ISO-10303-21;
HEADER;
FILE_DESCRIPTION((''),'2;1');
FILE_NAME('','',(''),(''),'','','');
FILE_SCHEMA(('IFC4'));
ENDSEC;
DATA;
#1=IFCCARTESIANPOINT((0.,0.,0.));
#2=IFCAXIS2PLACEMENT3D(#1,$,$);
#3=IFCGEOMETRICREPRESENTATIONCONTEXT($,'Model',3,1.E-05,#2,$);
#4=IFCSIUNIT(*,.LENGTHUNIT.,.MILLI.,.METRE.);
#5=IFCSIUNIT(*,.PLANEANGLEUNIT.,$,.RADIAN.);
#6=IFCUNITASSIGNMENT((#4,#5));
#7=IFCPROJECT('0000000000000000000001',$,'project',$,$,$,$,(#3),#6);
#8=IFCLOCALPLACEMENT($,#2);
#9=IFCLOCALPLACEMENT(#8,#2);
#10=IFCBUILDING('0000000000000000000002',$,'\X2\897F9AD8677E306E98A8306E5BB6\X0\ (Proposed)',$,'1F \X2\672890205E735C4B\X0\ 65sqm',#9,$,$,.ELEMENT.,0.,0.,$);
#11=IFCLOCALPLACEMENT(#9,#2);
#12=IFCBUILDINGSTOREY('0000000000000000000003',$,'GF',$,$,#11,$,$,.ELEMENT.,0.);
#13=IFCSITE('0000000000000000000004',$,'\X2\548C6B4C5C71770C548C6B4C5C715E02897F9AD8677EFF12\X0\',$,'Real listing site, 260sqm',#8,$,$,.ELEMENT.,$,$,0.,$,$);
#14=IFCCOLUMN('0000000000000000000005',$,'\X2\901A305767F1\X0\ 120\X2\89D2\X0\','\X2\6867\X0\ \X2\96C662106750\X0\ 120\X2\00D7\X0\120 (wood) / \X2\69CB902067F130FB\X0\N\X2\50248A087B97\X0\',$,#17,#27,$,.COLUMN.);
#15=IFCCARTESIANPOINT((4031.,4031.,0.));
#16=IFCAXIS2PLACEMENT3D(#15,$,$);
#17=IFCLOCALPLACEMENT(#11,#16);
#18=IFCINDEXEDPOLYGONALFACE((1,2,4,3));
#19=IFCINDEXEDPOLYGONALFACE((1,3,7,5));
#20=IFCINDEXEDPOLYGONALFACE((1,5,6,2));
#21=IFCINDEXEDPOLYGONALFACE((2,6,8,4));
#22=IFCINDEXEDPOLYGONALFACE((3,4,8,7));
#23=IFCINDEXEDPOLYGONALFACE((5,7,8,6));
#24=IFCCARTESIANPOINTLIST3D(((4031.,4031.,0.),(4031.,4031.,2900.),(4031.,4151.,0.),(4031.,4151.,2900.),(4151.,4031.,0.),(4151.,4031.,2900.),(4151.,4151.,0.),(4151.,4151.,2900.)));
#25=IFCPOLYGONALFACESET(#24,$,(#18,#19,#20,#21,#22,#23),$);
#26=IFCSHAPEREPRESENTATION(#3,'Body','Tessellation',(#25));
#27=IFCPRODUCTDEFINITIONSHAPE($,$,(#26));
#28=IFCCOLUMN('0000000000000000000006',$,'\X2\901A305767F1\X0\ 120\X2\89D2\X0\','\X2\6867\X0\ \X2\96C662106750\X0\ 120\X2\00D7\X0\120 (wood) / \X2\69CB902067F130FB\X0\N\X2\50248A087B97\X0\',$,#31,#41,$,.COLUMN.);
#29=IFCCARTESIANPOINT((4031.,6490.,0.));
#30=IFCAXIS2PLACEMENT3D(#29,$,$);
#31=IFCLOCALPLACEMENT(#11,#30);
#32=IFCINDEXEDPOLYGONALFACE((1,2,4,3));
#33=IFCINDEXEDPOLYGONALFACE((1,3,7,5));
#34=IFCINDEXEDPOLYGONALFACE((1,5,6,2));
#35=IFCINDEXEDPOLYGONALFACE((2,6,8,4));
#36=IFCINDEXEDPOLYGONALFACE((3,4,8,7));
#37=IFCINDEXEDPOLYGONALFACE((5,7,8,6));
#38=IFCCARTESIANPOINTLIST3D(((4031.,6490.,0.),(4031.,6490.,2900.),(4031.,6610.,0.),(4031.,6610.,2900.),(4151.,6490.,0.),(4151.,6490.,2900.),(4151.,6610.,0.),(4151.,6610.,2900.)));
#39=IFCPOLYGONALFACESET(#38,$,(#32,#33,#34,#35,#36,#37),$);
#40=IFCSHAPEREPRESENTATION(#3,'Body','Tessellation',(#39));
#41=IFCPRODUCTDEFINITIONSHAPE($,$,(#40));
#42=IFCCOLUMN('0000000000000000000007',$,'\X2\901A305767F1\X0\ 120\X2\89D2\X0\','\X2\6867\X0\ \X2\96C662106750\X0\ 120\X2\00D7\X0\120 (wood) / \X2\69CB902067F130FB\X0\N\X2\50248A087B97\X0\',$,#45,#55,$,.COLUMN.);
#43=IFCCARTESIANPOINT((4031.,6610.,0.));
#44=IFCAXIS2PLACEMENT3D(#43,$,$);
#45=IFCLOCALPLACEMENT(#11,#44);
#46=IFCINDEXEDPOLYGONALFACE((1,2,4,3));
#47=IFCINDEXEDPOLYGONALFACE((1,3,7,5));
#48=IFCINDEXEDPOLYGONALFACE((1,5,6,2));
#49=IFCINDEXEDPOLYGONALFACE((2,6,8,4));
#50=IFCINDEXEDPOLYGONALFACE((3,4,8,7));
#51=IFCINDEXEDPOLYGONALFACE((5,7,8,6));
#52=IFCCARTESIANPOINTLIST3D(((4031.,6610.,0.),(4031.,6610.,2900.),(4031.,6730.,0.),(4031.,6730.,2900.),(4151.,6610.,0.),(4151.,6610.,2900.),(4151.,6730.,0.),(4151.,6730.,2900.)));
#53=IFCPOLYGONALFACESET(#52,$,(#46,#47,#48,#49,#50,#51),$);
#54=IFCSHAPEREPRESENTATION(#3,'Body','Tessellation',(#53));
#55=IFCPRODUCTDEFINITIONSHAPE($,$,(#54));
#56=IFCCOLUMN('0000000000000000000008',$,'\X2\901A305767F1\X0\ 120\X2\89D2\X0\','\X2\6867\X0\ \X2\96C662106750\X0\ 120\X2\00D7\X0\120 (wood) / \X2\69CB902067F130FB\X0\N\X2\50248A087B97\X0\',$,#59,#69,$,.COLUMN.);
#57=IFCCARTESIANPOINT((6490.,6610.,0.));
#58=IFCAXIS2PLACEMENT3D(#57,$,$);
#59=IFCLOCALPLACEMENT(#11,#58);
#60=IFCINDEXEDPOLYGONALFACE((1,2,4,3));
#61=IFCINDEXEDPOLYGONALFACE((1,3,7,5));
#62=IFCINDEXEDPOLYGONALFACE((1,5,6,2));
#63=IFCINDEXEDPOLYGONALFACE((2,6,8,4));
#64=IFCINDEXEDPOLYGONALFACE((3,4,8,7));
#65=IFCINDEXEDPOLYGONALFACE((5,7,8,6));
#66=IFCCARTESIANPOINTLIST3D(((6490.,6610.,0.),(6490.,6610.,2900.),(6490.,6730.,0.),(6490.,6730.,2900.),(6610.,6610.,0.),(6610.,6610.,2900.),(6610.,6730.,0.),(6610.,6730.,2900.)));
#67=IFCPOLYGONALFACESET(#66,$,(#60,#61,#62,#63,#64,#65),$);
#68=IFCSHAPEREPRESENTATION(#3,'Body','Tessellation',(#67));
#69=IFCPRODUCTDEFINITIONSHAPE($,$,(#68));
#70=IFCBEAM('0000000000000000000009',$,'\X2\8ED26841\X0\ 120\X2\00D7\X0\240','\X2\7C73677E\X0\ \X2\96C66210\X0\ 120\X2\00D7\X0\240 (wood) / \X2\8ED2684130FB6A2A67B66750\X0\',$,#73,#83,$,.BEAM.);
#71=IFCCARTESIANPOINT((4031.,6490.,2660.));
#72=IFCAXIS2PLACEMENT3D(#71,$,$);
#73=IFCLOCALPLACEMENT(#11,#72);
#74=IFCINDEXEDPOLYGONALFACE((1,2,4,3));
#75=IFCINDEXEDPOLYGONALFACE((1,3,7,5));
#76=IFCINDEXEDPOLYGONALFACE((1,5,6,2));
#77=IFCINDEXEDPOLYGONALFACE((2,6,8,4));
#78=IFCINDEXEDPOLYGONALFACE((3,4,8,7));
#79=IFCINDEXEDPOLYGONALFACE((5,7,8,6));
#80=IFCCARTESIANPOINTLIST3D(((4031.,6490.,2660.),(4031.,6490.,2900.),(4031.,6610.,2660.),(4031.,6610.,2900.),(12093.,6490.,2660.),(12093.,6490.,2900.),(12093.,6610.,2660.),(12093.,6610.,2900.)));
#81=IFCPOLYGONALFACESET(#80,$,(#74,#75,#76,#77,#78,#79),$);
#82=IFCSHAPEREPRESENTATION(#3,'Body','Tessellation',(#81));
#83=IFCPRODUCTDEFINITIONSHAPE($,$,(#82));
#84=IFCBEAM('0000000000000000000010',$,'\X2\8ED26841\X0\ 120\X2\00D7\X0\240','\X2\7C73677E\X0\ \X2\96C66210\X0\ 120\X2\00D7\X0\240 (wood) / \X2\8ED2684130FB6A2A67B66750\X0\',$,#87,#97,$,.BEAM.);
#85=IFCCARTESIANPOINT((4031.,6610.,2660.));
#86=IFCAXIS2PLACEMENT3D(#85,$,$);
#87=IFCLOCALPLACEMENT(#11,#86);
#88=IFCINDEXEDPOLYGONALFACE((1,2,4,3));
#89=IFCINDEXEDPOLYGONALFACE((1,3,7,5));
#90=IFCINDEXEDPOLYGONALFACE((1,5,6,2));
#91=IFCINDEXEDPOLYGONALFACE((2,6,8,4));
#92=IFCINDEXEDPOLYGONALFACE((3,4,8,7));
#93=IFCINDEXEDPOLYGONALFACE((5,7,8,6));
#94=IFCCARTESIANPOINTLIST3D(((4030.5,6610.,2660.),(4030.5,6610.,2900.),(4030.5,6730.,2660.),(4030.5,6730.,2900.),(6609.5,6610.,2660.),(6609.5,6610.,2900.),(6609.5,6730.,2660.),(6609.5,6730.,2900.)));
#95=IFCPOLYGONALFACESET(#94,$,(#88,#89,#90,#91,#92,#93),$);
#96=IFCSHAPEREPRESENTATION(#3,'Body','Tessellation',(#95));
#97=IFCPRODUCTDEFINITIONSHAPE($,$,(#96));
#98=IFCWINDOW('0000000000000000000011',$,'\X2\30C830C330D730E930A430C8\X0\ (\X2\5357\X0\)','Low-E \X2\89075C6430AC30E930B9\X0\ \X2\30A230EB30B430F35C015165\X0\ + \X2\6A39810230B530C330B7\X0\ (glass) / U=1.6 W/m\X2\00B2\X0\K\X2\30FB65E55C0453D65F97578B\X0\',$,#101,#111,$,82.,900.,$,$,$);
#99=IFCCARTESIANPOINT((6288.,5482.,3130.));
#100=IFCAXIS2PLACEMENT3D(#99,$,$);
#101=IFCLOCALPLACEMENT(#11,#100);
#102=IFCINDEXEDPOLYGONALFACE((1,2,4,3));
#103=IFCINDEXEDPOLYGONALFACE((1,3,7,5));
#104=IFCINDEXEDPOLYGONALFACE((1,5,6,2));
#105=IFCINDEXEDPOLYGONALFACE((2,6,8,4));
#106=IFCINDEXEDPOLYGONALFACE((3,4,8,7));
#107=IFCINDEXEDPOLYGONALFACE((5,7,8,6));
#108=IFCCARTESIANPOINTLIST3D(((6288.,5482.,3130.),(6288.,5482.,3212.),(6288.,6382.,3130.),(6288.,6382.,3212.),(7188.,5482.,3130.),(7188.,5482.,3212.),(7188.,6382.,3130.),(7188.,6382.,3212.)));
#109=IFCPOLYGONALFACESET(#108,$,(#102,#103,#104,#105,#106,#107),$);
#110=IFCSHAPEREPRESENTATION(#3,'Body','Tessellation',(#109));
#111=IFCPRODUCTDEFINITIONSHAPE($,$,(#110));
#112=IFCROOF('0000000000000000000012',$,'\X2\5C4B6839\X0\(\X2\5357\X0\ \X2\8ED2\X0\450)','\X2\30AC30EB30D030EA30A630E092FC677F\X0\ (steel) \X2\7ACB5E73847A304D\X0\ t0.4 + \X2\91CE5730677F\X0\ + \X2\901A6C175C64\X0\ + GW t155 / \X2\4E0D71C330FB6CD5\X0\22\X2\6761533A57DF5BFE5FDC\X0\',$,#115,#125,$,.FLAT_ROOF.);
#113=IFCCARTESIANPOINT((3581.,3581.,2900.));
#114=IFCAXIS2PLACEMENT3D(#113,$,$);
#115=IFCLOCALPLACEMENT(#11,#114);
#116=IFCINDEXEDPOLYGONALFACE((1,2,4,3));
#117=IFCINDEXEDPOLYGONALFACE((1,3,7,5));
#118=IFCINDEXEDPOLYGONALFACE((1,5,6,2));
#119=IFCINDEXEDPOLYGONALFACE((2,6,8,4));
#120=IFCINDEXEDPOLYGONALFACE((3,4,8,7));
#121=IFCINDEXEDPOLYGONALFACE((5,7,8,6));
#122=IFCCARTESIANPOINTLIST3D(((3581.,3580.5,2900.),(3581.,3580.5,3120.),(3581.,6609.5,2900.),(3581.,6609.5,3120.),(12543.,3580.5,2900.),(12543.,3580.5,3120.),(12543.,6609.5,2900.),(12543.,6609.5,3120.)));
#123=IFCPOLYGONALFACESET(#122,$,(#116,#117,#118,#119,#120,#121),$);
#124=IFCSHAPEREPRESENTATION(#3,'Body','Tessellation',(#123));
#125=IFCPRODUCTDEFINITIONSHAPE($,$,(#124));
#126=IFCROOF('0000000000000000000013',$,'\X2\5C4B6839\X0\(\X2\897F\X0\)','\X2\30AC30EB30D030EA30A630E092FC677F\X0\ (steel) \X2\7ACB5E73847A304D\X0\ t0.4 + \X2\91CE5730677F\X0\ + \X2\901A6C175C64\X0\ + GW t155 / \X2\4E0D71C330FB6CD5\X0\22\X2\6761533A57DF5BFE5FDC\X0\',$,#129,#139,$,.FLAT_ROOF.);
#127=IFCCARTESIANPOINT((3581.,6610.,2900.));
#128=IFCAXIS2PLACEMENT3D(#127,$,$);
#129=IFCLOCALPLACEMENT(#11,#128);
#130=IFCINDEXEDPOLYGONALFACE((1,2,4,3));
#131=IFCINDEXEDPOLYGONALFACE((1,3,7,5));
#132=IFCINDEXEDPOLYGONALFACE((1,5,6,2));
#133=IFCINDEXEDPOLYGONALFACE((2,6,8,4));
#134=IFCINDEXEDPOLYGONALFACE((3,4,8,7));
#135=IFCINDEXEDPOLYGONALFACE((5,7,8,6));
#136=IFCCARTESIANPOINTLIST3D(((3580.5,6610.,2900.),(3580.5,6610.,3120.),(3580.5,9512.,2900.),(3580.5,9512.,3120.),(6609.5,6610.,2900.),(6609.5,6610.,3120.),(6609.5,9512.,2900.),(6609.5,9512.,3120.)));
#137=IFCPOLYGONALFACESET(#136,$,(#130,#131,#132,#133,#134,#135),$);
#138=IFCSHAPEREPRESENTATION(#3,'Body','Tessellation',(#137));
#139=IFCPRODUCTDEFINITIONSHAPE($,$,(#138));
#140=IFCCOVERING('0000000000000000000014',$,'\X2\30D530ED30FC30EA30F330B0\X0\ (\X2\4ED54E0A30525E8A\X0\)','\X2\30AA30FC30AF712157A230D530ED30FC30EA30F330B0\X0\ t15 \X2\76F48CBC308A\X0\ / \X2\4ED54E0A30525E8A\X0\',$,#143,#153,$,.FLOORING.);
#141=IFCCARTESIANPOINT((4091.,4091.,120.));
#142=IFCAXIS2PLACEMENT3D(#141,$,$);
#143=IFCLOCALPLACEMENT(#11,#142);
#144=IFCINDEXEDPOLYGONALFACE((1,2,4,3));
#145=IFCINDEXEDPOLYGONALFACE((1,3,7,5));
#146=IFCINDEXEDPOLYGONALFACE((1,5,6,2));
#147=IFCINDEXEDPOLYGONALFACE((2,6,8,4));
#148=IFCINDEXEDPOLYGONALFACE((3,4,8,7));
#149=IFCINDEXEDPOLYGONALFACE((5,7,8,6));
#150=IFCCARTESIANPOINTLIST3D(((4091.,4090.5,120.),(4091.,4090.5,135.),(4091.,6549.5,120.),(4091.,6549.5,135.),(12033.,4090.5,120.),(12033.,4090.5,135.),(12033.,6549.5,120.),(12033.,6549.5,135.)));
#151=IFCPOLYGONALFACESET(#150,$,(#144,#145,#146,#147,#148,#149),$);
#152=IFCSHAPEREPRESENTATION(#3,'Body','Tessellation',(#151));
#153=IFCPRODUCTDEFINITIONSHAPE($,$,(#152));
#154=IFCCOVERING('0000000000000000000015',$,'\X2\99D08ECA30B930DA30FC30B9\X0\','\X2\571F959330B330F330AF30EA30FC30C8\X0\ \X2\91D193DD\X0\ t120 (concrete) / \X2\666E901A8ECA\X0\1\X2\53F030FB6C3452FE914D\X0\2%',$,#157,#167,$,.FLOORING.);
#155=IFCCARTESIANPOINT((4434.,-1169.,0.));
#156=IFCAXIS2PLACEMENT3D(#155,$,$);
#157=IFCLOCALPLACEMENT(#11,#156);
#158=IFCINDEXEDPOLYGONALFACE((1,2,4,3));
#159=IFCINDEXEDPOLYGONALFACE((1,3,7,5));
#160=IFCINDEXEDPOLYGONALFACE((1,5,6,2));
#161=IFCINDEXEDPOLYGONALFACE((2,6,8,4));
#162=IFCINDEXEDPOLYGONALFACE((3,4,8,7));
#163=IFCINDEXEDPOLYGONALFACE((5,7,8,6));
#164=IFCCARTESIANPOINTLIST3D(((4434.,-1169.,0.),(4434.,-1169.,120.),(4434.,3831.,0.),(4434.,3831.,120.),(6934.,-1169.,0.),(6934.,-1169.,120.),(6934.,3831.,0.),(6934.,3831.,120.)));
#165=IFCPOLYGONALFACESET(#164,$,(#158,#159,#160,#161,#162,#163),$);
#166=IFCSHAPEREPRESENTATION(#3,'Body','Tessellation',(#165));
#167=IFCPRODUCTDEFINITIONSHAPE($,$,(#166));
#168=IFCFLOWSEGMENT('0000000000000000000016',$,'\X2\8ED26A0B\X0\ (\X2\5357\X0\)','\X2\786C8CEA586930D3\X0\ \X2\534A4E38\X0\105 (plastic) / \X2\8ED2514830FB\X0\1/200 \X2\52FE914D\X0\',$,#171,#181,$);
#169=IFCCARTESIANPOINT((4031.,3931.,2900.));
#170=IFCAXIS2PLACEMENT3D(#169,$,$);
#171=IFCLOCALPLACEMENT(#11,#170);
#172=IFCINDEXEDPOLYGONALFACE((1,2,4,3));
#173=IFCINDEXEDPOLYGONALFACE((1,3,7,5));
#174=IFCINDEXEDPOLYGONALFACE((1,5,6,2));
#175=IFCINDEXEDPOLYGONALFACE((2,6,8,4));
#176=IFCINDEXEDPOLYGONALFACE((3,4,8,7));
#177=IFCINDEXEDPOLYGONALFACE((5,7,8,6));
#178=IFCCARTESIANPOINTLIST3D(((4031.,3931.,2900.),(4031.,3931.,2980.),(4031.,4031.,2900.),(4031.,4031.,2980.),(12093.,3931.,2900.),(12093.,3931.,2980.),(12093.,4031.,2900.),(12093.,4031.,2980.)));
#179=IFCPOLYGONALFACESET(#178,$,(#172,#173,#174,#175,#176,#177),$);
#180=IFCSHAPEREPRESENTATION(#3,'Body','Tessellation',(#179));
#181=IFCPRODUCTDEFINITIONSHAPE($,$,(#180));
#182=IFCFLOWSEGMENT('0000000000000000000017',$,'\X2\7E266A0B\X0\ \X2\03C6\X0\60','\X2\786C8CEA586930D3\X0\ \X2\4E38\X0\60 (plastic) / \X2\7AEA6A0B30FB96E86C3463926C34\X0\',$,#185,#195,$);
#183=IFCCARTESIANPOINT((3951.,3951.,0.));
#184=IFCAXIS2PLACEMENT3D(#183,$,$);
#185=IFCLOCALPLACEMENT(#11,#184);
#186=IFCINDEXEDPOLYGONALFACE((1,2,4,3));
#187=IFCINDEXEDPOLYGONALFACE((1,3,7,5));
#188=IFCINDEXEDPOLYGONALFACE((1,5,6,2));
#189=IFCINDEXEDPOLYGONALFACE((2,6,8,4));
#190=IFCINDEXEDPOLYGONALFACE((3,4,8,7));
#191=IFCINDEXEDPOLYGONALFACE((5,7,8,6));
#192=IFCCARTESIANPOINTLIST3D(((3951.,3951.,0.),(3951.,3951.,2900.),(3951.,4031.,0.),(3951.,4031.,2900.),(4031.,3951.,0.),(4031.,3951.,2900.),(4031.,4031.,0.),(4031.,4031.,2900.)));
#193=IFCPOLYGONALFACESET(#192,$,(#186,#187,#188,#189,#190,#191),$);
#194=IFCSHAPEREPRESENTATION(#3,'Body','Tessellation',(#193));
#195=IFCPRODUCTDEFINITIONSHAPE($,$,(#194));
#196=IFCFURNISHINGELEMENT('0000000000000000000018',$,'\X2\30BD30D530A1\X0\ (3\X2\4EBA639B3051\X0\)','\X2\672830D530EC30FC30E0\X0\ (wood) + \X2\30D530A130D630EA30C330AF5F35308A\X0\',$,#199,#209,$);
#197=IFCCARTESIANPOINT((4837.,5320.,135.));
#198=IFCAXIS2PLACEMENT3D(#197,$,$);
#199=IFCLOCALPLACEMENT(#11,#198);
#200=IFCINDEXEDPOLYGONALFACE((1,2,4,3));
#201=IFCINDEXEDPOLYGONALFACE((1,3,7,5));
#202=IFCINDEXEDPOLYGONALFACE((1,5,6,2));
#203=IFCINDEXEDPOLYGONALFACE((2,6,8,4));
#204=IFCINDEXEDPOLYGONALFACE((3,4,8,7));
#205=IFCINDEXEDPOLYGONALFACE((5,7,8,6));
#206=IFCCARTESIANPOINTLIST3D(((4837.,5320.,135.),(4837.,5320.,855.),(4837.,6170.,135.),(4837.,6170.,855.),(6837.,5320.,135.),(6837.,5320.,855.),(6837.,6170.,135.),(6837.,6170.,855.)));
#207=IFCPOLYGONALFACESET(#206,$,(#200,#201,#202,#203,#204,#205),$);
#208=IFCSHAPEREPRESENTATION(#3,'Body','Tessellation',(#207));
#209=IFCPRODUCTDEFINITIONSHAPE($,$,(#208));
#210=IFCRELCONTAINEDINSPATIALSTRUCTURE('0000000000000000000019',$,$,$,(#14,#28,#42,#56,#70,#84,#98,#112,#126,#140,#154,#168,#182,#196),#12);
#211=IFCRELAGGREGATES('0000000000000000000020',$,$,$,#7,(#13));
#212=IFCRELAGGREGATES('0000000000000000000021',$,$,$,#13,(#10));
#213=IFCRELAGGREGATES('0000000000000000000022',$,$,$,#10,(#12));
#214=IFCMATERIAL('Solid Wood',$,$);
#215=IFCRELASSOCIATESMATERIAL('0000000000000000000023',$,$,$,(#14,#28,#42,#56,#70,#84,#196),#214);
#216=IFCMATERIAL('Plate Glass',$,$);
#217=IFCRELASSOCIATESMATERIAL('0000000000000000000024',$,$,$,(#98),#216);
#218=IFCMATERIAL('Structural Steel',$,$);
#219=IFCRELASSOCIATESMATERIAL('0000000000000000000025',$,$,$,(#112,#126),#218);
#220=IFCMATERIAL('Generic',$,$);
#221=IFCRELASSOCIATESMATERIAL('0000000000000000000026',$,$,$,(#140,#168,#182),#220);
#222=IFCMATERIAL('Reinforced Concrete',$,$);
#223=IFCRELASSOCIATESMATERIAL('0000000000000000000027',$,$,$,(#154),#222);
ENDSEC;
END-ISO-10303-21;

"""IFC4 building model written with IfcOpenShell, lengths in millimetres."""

from ifc_helpers import new_model, si_unit, frame, frame_2d, origin, place, context, project, spatial, rectangle, extrude, material, element, save


model = new_model("IFC4")

# Units and contexts
model_context = context("Model", 3, precision=1e-05, world=origin())
ifc_project = project(units=[si_unit("LENGTHUNIT", "METRE", prefix="MILLI"), si_unit("PLANEANGLEUNIT", "RADIAN")], contexts=[model_context])

# Site, building, storey
site_placement = place(None, origin())
site = spatial("IfcSite", under=ifc_project, at=site_placement, Name="和歌山県和歌山市西高松２", ObjectType="Real listing site, 260sqm", CompositionType="ELEMENT", RefElevation=0.0)
building_placement = place(site_placement, origin())
building = spatial("IfcBuilding", under=site, at=building_placement, Name="西高松の風の家 (Proposed)", ObjectType="1F 木造平屋 65sqm", CompositionType="ELEMENT", ElevationOfRefHeight=0.0, ElevationOfTerrain=0.0)
storey_placement = place(building_placement, origin())
storey = spatial("IfcBuildingStorey", under=building, at=storey_placement, Name="GF", CompositionType="ELEMENT", Elevation=0.0)

# Columns
ifc_material_1 = material(Name="Solid Wood")
column_1_placement = place(storey_placement, frame((4031.0, 4031.0, 0.0)))
element("IfcColumn", 1, at=column_1_placement, inside=storey, material=ifc_material_1, Name="通し柱 120角", Description="桧 集成材 120×120 (wood) / 構造柱・N値計算", PredefinedType="COLUMN", context=model_context, shape_type="SweptSolid", body=[
    extrude(rectangle(XDim=120.0, YDim=120.0, at=frame_2d((60.0, 60.0))), frame((4031.0, 4031.0, 0.0)), (0.0, 0.0, 1.0), 2900.0),
])
column_2_placement = place(storey_placement, frame((4031.0, 6490.0, 0.0)))
element("IfcColumn", 2, at=column_2_placement, inside=storey, material=ifc_material_1, Name="通し柱 120角", Description="桧 集成材 120×120 (wood) / 構造柱・N値計算", PredefinedType="COLUMN", context=model_context, shape_type="SweptSolid", body=[
    extrude(rectangle(XDim=120.0, YDim=120.0, at=frame_2d((60.0, 60.0))), frame((4031.0, 6490.0, 0.0)), (0.0, 0.0, 1.0), 2900.0),
])
column_3_placement = place(storey_placement, frame((4031.0, 6610.0, 0.0)))
element("IfcColumn", 3, at=column_3_placement, inside=storey, material=ifc_material_1, Name="通し柱 120角", Description="桧 集成材 120×120 (wood) / 構造柱・N値計算", PredefinedType="COLUMN", context=model_context, shape_type="SweptSolid", body=[
    extrude(rectangle(XDim=120.0, YDim=120.0, at=frame_2d((60.0, 60.0))), frame((4031.0, 6610.0, 0.0)), (0.0, 0.0, 1.0), 2900.0),
])
column_4_placement = place(storey_placement, frame((6490.0, 6610.0, 0.0)))
element("IfcColumn", 4, at=column_4_placement, inside=storey, material=ifc_material_1, Name="通し柱 120角", Description="桧 集成材 120×120 (wood) / 構造柱・N値計算", PredefinedType="COLUMN", context=model_context, shape_type="SweptSolid", body=[
    extrude(rectangle(XDim=120.0, YDim=120.0, at=frame_2d((60.0, 60.0))), frame((6490.0, 6610.0, 0.0)), (0.0, 0.0, 1.0), 2900.0),
])

# Beams
beam_1_placement = place(storey_placement, frame((4031.0, 6490.0, 2660.0)))
element("IfcBeam", 5, at=beam_1_placement, inside=storey, material=ifc_material_1, Name="軒桁 120×240", Description="米松 集成 120×240 (wood) / 軒桁・横架材", PredefinedType="BEAM", context=model_context, shape_type="SweptSolid", body=[
    extrude(rectangle(XDim=8062.0, YDim=120.0, at=frame_2d((4031.0, 60.0))), frame((4031.0, 6490.0, 2660.0)), (0.0, 0.0, 1.0), 240.0),
])
beam_2_placement = place(storey_placement, frame((4031.0, 6610.0, 2660.0)))
element("IfcBeam", 6, at=beam_2_placement, inside=storey, material=ifc_material_1, Name="軒桁 120×240", Description="米松 集成 120×240 (wood) / 軒桁・横架材", PredefinedType="BEAM", context=model_context, shape_type="SweptSolid", body=[
    extrude(rectangle(XDim=2579.0, YDim=120.0, at=frame_2d((1289.0, 60.0))), frame((4031.0, 6610.0, 2660.0)), (0.0, 0.0, 1.0), 240.0),
])

# Shared definitions
ifc_material_2 = material(Name="Reinforced Concrete")

# Shared definitions
ifc_material_3 = material(Name="Plate Glass")

# Window
window_1_placement = place(storey_placement, frame((6288.0, 5482.0, 3130.0)))
element("IfcWindow", 7, at=window_1_placement, inside=storey, material=ifc_material_3, Name="トップライト (南)", Description="Low-E 複層ガラス アルゴン封入 + 樹脂サッシ (glass) / U=1.6 W/m²K・日射取得型", OverallHeight=82.0, OverallWidth=900.0, context=model_context, shape_type="SweptSolid", body=[
    extrude(rectangle(XDim=900.0, YDim=900.0, at=frame_2d((450.0, 450.0))), frame((6288.0, 5482.0, 3130.0)), (0.0, 0.0, 1.0), 82.0),
])

# Roofs
ifc_material_4 = material(Name="Structural Steel")
roof_1_placement = place(storey_placement, frame((3581.0, 3581.0, 2900.0)))
element("IfcRoof", 8, at=roof_1_placement, inside=storey, material=ifc_material_4, Name="屋根(南 軒450)", Description="ガルバリウム鋼板 (steel) 立平葺き t0.4 + 野地板 + 通気層 + GW t155 / 不燃・法22条区域対応", PredefinedType="FLAT_ROOF", context=model_context, shape_type="SweptSolid", body=[
    extrude(rectangle(XDim=8962.0, YDim=3029.0, at=frame_2d((4481.0, 1514.0))), frame((3581.0, 3581.0, 2900.0)), (0.0, 0.0, 1.0), 220.0),
])
roof_2_placement = place(storey_placement, frame((3581.0, 6610.0, 2900.0)))
element("IfcRoof", 9, at=roof_2_placement, inside=storey, material=ifc_material_4, Name="屋根(西)", Description="ガルバリウム鋼板 (steel) 立平葺き t0.4 + 野地板 + 通気層 + GW t155 / 不燃・法22条区域対応", PredefinedType="FLAT_ROOF", context=model_context, shape_type="SweptSolid", body=[
    extrude(rectangle(XDim=3029.0, YDim=2902.0, at=frame_2d((1514.0, 1451.0))), frame((3581.0, 6610.0, 2900.0)), (0.0, 0.0, 1.0), 220.0),
])

# Coverings
ifc_material_5 = material(Name="Generic")
covering_1_placement = place(storey_placement, frame((4091.0, 4091.0, 120.0)))
element("IfcCovering", 10, at=covering_1_placement, inside=storey, material=ifc_material_5, Name="フローリング (仕上げ床)", Description="オーク無垢フローリング t15 直貼り / 仕上げ床", PredefinedType="FLOORING", context=model_context, shape_type="SweptSolid", body=[
    extrude(rectangle(XDim=7942.0, YDim=2459.0, at=frame_2d((3971.0, 1229.0))), frame((4091.0, 4091.0, 120.0)), (0.0, 0.0, 1.0), 15.0),
])
covering_2_placement = place(storey_placement, frame((4434.0, -1169.0, 0.0)))
element("IfcCovering", 11, at=covering_2_placement, inside=storey, material=ifc_material_2, Name="駐車スペース", Description="土間コンクリート 金鏝 t120 (concrete) / 普通車1台・水勾配2%", PredefinedType="FLOORING", context=model_context, shape_type="SweptSolid", body=[
    extrude(rectangle(XDim=2500.0, YDim=5000.0, at=frame_2d((1250.0, 2500.0))), frame((4434.0, -1169.0, 0.0)), (0.0, 0.0, 1.0), 120.0),
])

# Flow segments
flow_segment_1_placement = place(storey_placement, frame((4031.0, 3931.0, 2900.0)))
element("IfcFlowSegment", 12, at=flow_segment_1_placement, inside=storey, material=ifc_material_5, Name="軒樋 (南)", Description="硬質塩ビ 半丸105 (plastic) / 軒先・1/200 勾配", context=model_context, shape_type="SweptSolid", body=[
    extrude(rectangle(XDim=8062.0, YDim=100.0, at=frame_2d((4031.0, 50.0))), frame((4031.0, 3931.0, 2900.0)), (0.0, 0.0, 1.0), 80.0),
])
flow_segment_2_placement = place(storey_placement, frame((3951.0, 3951.0, 0.0)))
element("IfcFlowSegment", 13, at=flow_segment_2_placement, inside=storey, material=ifc_material_5, Name="縦樋 φ60", Description="硬質塩ビ 丸60 (plastic) / 竪樋・雨水排水", context=model_context, shape_type="SweptSolid", body=[
    extrude(rectangle(XDim=80.0, YDim=80.0, at=frame_2d((40.0, 40.0))), frame((3951.0, 3951.0, 0.0)), (0.0, 0.0, 1.0), 2900.0),
])

# Furnishing element
furnishing_1_placement = place(storey_placement, frame((4837.0, 5320.0, 135.0)))
element("IfcFurnishingElement", 14, at=furnishing_1_placement, inside=storey, material=ifc_material_1, Name="ソファ (3人掛け)", Description="木フレーム (wood) + ファブリック張り", context=model_context, shape_type="SweptSolid", body=[
    extrude(rectangle(XDim=2000.0, YDim=850.0, at=frame_2d((1000.0, 425.0))), frame((4837.0, 5320.0, 135.0)), (0.0, 0.0, 1.0), 720.0),
])

save(model, "model.ifc")
